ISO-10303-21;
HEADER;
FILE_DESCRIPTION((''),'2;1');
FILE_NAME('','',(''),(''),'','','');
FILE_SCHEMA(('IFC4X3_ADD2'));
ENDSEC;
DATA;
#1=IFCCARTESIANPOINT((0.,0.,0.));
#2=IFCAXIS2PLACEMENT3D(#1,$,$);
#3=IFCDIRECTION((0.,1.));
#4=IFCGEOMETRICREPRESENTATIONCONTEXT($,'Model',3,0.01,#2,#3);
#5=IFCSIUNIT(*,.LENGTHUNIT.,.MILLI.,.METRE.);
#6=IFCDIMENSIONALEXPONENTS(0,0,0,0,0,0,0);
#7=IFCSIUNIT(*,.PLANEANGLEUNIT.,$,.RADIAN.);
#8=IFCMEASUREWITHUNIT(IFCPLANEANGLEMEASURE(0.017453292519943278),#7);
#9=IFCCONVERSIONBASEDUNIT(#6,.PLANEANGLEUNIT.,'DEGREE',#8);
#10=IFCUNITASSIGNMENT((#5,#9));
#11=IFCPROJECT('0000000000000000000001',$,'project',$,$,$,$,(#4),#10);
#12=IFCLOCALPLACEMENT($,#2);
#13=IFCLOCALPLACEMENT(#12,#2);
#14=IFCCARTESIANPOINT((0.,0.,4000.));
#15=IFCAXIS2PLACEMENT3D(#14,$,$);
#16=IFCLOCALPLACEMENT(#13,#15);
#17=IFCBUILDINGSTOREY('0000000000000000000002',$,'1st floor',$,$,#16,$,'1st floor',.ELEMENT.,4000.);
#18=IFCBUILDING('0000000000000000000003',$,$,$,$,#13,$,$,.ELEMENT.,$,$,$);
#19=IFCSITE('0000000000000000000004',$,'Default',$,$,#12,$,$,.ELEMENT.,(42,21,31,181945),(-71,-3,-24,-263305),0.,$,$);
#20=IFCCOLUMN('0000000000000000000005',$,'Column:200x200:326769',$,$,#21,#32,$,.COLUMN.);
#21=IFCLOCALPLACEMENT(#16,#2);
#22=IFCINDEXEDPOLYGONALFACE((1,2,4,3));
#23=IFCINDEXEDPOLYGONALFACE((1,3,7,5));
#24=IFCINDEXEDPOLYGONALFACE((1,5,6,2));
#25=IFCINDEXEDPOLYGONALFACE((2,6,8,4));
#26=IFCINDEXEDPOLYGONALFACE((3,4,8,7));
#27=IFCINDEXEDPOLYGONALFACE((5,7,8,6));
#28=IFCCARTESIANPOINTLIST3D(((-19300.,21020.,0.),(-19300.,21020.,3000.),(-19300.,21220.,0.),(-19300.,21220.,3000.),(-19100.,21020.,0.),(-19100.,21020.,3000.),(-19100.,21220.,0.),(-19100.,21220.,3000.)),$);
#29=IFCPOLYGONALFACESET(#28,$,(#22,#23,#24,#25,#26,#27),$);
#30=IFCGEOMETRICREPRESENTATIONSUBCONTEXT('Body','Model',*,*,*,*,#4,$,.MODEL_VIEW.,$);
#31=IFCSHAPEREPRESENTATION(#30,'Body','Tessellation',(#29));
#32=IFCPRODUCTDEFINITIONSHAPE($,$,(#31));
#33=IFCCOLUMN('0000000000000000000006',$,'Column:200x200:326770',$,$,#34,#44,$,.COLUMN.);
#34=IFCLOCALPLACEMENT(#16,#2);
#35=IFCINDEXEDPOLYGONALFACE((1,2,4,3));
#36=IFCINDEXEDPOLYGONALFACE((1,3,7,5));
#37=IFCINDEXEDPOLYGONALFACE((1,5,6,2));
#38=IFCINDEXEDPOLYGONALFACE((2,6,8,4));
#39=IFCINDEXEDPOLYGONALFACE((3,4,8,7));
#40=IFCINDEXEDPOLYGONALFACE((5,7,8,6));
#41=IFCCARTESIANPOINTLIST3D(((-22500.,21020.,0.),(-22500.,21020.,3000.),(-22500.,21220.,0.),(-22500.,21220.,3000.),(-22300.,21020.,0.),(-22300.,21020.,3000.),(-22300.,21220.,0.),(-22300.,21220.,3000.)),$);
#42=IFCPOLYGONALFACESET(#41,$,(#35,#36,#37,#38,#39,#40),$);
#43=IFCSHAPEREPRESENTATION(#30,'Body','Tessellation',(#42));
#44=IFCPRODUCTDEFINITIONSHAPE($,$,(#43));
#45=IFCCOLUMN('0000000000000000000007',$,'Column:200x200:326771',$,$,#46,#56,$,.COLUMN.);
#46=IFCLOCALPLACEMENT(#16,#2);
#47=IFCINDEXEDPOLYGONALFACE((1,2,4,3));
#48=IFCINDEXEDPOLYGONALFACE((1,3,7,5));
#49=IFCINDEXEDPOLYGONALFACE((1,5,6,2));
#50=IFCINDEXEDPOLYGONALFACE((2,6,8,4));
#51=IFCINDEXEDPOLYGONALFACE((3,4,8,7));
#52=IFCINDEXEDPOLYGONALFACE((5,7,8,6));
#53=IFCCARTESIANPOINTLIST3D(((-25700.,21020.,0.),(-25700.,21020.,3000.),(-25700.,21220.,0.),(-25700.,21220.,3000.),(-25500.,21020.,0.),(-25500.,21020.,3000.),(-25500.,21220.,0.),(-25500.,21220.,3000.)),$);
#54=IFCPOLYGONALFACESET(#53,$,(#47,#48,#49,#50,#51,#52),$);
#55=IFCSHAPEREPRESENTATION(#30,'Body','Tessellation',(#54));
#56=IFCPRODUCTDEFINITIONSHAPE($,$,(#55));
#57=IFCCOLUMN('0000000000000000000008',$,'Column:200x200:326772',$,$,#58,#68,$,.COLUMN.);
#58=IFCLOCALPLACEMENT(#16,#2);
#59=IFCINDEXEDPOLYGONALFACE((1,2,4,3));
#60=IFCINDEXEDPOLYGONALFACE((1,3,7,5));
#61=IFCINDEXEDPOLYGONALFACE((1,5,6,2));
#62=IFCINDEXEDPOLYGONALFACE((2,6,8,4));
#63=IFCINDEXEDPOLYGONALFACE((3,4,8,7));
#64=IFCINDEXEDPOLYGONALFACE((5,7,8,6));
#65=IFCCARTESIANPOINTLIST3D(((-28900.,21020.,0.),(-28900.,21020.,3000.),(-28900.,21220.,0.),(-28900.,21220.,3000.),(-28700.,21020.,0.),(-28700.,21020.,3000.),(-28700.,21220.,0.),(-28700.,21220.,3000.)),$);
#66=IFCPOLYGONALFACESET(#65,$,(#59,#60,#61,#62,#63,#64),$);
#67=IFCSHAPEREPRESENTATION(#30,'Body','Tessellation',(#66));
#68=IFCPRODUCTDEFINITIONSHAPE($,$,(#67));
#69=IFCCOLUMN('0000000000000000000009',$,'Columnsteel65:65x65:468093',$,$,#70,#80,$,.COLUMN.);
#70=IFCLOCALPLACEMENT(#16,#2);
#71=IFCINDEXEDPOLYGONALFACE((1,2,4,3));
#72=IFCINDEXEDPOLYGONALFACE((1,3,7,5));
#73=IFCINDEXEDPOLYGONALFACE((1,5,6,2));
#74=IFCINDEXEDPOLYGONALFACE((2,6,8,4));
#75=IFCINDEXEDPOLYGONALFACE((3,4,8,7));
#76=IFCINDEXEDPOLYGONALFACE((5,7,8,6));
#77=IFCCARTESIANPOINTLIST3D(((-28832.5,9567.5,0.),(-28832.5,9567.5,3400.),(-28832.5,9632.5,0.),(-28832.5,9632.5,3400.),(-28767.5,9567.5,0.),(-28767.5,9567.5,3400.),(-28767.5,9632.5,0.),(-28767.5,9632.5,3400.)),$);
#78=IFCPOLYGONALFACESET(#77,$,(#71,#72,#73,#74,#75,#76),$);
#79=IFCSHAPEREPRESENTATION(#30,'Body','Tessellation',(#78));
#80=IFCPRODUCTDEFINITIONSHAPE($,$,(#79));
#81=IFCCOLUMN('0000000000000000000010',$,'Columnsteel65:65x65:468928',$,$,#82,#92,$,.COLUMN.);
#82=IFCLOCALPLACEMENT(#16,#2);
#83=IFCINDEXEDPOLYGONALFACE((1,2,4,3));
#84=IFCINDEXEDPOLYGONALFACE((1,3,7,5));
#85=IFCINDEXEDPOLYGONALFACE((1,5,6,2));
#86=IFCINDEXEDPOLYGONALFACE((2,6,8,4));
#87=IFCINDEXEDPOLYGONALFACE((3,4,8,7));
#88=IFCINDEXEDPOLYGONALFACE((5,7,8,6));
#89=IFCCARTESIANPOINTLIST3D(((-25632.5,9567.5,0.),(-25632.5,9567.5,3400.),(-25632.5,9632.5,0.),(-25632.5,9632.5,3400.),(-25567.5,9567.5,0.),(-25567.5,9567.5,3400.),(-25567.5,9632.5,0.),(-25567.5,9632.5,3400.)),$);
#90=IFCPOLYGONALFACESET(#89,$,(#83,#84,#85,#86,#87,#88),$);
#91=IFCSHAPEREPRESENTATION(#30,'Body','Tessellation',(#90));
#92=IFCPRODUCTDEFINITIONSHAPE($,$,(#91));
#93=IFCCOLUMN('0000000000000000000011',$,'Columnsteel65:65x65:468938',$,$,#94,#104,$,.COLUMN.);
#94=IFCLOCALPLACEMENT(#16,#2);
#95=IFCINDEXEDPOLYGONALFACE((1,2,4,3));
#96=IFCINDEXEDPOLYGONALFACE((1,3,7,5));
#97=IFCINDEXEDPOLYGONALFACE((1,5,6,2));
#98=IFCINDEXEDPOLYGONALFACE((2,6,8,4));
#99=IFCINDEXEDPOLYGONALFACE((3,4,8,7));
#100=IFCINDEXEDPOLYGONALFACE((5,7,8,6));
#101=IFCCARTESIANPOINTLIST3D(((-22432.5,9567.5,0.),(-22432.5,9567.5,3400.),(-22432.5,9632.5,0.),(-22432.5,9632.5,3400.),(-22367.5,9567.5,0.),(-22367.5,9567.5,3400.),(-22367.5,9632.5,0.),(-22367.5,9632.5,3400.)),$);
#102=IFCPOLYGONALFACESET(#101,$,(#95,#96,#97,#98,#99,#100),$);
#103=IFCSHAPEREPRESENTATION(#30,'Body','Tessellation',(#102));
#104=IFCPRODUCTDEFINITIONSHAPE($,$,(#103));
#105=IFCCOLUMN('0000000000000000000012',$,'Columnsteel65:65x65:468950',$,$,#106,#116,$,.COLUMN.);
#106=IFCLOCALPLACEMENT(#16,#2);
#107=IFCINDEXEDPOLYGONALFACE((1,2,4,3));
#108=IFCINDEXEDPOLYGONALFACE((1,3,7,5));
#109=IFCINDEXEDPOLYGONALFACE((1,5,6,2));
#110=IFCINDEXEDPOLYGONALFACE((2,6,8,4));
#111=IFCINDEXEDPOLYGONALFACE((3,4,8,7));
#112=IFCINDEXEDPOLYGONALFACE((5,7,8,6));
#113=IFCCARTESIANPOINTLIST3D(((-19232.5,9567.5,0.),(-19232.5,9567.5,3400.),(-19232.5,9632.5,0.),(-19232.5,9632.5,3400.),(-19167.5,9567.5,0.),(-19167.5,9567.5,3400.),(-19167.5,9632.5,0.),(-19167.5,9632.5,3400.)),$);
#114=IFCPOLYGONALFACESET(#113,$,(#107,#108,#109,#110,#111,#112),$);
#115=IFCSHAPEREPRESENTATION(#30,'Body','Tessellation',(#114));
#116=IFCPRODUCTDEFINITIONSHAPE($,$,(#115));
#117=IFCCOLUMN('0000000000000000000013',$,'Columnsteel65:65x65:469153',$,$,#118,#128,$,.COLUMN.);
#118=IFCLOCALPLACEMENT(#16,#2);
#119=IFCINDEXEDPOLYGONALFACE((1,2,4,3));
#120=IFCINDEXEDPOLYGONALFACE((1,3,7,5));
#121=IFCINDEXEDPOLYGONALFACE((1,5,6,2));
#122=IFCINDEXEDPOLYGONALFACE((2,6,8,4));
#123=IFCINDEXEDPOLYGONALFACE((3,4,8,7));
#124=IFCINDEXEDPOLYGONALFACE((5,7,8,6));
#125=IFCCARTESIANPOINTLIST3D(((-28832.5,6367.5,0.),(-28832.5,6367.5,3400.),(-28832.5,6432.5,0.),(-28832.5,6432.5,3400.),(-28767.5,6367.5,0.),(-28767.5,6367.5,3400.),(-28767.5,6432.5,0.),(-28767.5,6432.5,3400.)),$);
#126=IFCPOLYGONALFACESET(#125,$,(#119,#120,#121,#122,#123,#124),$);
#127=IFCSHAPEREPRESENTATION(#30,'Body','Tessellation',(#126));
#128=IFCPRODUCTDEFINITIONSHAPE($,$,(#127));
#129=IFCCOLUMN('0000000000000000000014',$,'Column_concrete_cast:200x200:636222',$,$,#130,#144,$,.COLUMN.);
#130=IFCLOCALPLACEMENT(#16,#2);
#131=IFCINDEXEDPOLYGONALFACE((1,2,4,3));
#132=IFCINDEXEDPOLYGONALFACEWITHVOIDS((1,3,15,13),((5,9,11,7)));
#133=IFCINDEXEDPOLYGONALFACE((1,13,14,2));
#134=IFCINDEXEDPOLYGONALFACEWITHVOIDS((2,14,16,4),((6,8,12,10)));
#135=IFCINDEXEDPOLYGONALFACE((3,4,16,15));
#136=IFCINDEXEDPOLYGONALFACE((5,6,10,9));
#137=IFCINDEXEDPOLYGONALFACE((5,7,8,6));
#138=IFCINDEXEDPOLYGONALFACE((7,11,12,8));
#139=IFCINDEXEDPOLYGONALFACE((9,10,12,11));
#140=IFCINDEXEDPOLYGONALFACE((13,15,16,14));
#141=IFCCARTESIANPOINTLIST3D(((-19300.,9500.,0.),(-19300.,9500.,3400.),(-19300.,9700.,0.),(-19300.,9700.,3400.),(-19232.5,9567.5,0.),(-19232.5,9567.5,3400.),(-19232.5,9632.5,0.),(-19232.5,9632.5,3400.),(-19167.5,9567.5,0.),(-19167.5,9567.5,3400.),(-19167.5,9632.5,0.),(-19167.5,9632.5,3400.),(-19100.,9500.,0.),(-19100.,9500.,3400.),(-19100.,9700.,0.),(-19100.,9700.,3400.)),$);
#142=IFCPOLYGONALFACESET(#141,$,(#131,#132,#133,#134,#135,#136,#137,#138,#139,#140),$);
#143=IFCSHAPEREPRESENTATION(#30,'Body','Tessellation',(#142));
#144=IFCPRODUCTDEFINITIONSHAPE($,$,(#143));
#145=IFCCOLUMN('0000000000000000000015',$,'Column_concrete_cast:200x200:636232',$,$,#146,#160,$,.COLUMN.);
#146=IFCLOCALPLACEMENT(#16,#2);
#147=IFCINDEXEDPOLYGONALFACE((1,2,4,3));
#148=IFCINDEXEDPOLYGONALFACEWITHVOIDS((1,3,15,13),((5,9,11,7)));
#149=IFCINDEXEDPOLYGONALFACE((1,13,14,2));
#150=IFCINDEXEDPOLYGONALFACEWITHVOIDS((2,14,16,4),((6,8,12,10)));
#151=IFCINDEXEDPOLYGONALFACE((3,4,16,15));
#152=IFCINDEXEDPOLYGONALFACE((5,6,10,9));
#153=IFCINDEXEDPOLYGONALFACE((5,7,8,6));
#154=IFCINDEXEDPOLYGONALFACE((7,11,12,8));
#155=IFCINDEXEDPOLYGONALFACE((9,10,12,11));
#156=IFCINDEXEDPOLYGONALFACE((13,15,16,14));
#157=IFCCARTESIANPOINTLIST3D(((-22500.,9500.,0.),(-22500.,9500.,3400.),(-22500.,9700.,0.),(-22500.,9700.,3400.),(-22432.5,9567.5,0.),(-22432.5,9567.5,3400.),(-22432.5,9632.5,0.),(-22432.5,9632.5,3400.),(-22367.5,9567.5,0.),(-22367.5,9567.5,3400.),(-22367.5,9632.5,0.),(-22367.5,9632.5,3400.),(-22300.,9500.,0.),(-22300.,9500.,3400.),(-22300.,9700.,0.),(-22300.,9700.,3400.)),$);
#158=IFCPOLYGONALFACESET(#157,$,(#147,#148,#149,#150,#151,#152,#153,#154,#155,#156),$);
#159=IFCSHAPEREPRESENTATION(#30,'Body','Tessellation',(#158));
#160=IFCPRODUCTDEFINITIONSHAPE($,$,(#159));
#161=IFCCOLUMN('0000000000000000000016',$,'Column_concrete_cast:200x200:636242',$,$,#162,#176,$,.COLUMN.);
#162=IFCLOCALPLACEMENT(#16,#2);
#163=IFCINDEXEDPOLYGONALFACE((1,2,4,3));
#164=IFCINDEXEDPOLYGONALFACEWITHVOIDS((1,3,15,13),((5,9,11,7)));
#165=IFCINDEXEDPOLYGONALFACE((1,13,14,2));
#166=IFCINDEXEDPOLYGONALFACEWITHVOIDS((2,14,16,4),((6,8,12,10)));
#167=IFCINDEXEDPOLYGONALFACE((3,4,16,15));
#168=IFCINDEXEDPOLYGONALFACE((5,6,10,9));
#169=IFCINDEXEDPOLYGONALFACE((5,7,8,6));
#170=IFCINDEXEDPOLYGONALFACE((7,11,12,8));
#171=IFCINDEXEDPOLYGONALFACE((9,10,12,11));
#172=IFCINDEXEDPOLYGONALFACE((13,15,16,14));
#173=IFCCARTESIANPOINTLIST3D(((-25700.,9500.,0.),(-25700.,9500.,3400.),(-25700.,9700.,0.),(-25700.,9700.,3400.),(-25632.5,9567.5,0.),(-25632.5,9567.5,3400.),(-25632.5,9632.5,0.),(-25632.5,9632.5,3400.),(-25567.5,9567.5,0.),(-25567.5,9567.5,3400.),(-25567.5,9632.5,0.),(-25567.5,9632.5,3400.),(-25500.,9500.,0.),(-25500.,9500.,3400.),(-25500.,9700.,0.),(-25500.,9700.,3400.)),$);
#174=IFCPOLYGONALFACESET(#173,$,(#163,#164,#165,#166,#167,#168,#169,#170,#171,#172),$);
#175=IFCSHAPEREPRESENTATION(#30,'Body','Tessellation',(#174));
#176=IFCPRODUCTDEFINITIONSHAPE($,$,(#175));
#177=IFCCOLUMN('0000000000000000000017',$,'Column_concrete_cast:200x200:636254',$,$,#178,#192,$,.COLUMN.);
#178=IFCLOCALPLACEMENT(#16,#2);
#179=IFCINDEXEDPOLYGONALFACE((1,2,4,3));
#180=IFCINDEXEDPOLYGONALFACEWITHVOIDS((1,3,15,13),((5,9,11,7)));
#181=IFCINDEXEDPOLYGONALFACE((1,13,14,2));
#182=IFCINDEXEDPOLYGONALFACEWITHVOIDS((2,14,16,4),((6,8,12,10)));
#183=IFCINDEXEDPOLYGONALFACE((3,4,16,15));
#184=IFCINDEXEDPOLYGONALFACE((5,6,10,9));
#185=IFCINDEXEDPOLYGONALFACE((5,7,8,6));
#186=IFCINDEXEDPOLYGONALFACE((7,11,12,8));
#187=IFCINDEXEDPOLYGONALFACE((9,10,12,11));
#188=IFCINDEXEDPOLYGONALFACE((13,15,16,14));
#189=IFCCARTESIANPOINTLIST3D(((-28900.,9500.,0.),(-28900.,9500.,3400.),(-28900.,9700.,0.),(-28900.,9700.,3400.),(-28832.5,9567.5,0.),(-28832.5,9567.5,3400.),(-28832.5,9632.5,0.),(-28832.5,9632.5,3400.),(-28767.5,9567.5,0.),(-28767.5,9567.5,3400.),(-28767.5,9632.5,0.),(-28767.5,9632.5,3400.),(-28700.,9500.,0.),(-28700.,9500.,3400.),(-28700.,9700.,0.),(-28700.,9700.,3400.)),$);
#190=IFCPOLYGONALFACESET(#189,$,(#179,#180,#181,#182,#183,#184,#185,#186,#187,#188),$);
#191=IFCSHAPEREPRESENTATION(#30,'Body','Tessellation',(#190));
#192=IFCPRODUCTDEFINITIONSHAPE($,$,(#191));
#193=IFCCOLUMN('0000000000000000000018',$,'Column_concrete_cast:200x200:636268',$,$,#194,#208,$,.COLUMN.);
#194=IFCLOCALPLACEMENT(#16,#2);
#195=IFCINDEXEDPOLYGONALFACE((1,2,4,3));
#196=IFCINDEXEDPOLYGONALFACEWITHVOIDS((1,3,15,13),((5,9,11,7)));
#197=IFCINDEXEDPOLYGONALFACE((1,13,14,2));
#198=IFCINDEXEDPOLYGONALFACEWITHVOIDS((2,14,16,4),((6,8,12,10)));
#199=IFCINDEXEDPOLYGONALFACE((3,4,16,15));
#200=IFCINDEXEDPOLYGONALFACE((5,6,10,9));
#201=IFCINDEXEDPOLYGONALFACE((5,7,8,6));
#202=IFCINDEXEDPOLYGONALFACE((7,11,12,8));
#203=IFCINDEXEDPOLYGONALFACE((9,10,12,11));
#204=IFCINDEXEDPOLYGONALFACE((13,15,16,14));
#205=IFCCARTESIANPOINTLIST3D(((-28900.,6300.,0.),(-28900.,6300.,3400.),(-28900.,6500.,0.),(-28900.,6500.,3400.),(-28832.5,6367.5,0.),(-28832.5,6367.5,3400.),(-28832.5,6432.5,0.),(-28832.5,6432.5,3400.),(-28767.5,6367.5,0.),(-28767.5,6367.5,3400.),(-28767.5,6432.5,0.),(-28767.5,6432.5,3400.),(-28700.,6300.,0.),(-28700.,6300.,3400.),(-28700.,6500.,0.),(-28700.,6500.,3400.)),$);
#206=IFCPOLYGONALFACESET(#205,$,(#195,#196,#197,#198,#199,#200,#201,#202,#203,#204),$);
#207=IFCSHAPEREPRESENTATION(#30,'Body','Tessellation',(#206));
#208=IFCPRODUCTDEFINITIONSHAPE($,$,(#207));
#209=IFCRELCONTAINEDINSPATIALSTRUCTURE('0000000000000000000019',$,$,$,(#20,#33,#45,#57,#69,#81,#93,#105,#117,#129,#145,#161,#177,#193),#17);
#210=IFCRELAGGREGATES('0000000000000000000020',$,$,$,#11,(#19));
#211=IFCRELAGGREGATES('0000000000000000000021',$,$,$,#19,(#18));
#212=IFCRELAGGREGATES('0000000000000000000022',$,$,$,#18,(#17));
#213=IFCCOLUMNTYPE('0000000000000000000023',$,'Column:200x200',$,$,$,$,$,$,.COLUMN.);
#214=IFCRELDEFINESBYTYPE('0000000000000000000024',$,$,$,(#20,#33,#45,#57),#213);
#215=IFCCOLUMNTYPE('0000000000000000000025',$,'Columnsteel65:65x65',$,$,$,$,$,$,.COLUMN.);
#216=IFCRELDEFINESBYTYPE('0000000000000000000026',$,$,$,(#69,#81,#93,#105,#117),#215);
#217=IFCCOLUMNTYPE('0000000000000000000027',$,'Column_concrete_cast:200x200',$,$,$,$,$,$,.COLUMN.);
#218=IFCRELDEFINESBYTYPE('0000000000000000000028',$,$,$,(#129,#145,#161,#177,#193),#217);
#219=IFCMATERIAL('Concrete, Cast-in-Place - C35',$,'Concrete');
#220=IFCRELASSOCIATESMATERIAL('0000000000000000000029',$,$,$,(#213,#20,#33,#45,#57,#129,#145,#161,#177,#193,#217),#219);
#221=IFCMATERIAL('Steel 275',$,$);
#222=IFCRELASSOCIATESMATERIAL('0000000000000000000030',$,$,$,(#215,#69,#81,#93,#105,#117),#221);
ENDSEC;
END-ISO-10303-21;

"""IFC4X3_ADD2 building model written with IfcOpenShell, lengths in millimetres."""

from ifc_helpers import new_model, entity, si_unit, converted_unit, direction, frame, frame_2d, origin, place, context, subcontext, project, spatial, polyline, rectangle, outline, extrude, source, transform, mapped, material, material_profile, profile_set, profile_usage, type_object, type_shapes, element, save


model = new_model("IFC4X3_ADD2")

# Units and contexts
model_context = context("Model", 3, precision=0.01, world=origin(), true_north=direction((0.0, 1.0)))
body_context = subcontext(model_context, "Body", "Model", "MODEL_VIEW")
ifc_project = project(units=[si_unit("LENGTHUNIT", "METRE", prefix="MILLI"), converted_unit("PLANEANGLEUNIT", "DEGREE", entity("IfcPlaneAngleMeasure", 0.017453292519943278), si_unit("PLANEANGLEUNIT", "RADIAN"), dimensions=[0, 0, 0, 0, 0, 0, 0])], contexts=[model_context])

# Site, building, storey
site_placement = place(None, origin())
site = spatial("IfcSite", under=ifc_project, at=site_placement, Name="Default", CompositionType="ELEMENT", RefLatitude=(42, 21, 31, 181945), RefLongitude=(-71, -3, -24, -263305), RefElevation=0.0)
building_placement = place(site_placement, origin())
building = spatial("IfcBuilding", under=site, at=building_placement, CompositionType="ELEMENT")
storey_placement = place(building_placement, frame((0.0, 0.0, 4000.0)))
storey = spatial("IfcBuildingStorey", under=building, at=storey_placement, Name="1st floor", LongName="1st floor", CompositionType="ELEMENT", Elevation=4000.0)

# Columns
ifc_material_1 = material(Name="Concrete, Cast-in-Place - C35", Category="Concrete")
ifc_material_profile_1 = material_profile(ifc_material_1, rectangle(XDim=200.0, YDim=200.0, at=frame_2d((0.0, 0.0), x_axis=(1.0, 0.0))), Name="200x200")
ifc_profile_set_1 = profile_set([ifc_material_profile_1], Name="200x200")
ifc_profile_usage_1 = profile_usage(ifc_profile_set_1)
column_type_1 = type_object("IfcColumnType", Name="Column:200x200", PredefinedType="COLUMN", material=ifc_profile_set_1)
shared_shape_1 = source(origin(), body_context, "Body", "SweptSolid", [
    extrude(rectangle(XDim=200.0, YDim=200.0, at=frame_2d((0.0, 0.0), x_axis=(1.0, 0.0))), frame((0.0, 0.0, 4000.0), z_axis=(0.0, 0.0, 1.0), x_axis=(-1.0, 0.0, 0.0)), (0.0, 0.0, 1.0), 3000.0),
])
type_shapes(column_type_1, [shared_shape_1])
for number, where, name in (
    (1, (-19200.0, 21120.0, -4000.0), "Column:200x200:326769"),
    (2, (-22400.0, 21120.0, -4000.0), "Column:200x200:326770"),
    (3, (-25600.0, 21120.0, -4000.0), "Column:200x200:326771"),
    (4, (-28800.0, 21120.0, -4000.0), "Column:200x200:326772"),
):
    element("IfcColumn", number, at=place(storey_placement, frame(where)), inside=storey, type_object=column_type_1, material=ifc_profile_usage_1, Name=name, PredefinedType="COLUMN", context=body_context, shape_type="MappedRepresentation", body=[
        mapped(shared_shape_1, transform((0.0, 0.0, 0.0), scale=1.0)),
    ])
ifc_material_2 = material(Name="Steel 275")
ifc_material_profile_2 = material_profile(ifc_material_2, rectangle(XDim=65.0, YDim=65.0, at=frame_2d((0.0, 0.0), x_axis=(1.0, 0.0))), Name="65x65")
ifc_profile_set_2 = profile_set([ifc_material_profile_2], Name="65x65")
ifc_profile_usage_2 = profile_usage(ifc_profile_set_2)
column_type_2 = type_object("IfcColumnType", Name="Columnsteel65:65x65", PredefinedType="COLUMN", material=ifc_profile_set_2)
shared_shape_2 = source(origin(), body_context, "Body", "SweptSolid", [
    extrude(rectangle(XDim=65.0, YDim=65.0, at=frame_2d((0.0, 0.0), x_axis=(1.0, 0.0))), frame((0.0, 0.0, 4000.0), z_axis=(0.0, 0.0, 1.0), x_axis=(-1.0, 0.0, 0.0)), (0.0, 0.0, 1.0), 3400.0),
])
type_shapes(column_type_2, [shared_shape_2])
for number, where, name in (
    (5, (-28800.0, 9600.0, -4000.0), "Columnsteel65:65x65:468093"),
    (6, (-25600.0, 9600.0, -4000.0), "Columnsteel65:65x65:468928"),
    (7, (-22400.0, 9600.0, -4000.0), "Columnsteel65:65x65:468938"),
    (8, (-19200.0, 9600.0, -4000.0), "Columnsteel65:65x65:468950"),
    (9, (-28800.0, 6400.0, -4000.0), "Columnsteel65:65x65:469153"),
):
    element("IfcColumn", number, at=place(storey_placement, frame(where)), inside=storey, type_object=column_type_2, material=ifc_profile_usage_2, Name=name, PredefinedType="COLUMN", context=body_context, shape_type="MappedRepresentation", body=[
        mapped(shared_shape_2, transform((0.0, 0.0, 0.0), scale=1.0)),
    ])
ifc_material_profile_3 = material_profile(ifc_material_1, outline(polyline([(-100.0, -100.0), (100.0, -100.0), (100.0, 100.0), (-100.0, 100.0), (-100.0, -100.0)]), holes=[polyline([(-32.5, 32.5), (32.5, 32.5), (32.5, -32.5), (-32.5, -32.5), (-32.5, 32.5)])]), Name="200x200")
ifc_profile_set_3 = profile_set([ifc_material_profile_3], Name="200x200")
column_type_3 = type_object("IfcColumnType", Name="Column_concrete_cast:200x200", PredefinedType="COLUMN", material=ifc_profile_set_3)
shared_shape_3 = source(origin(), body_context, "Body", "SweptSolid", [
    extrude(outline(polyline([(-100.0, -100.0), (100.0, -100.0), (100.0, 100.0), (-100.0, 100.0), (-100.0, -100.0)]), holes=[polyline([(-32.5, 32.5), (32.5, 32.5), (32.5, -32.5), (-32.5, -32.5), (-32.5, 32.5)])]), frame((0.0, 0.0, 4000.0), z_axis=(0.0, 0.0, 1.0), x_axis=(-1.0, 0.0, 0.0)), (0.0, 0.0, 1.0), 3400.0),
])
type_shapes(column_type_3, [shared_shape_3])
for number, where, name in (
    (10, (-19200.0, 9600.0, -4000.0), "Column_concrete_cast:200x200:636222"),
    (11, (-22400.0, 9600.0, -4000.0), "Column_concrete_cast:200x200:636232"),
    (12, (-25600.0, 9600.0, -4000.0), "Column_concrete_cast:200x200:636242"),
    (13, (-28800.0, 9600.0, -4000.0), "Column_concrete_cast:200x200:636254"),
    (14, (-28800.0, 6400.0, -4000.0), "Column_concrete_cast:200x200:636268"),
):
    element("IfcColumn", number, at=place(storey_placement, frame(where)), inside=storey, type_object=column_type_3, material=ifc_profile_usage_1, Name=name, PredefinedType="COLUMN", context=body_context, shape_type="MappedRepresentation", body=[
        mapped(shared_shape_3, transform((0.0, 0.0, 0.0), scale=1.0)),
    ])

save(model, "model.ifc")
